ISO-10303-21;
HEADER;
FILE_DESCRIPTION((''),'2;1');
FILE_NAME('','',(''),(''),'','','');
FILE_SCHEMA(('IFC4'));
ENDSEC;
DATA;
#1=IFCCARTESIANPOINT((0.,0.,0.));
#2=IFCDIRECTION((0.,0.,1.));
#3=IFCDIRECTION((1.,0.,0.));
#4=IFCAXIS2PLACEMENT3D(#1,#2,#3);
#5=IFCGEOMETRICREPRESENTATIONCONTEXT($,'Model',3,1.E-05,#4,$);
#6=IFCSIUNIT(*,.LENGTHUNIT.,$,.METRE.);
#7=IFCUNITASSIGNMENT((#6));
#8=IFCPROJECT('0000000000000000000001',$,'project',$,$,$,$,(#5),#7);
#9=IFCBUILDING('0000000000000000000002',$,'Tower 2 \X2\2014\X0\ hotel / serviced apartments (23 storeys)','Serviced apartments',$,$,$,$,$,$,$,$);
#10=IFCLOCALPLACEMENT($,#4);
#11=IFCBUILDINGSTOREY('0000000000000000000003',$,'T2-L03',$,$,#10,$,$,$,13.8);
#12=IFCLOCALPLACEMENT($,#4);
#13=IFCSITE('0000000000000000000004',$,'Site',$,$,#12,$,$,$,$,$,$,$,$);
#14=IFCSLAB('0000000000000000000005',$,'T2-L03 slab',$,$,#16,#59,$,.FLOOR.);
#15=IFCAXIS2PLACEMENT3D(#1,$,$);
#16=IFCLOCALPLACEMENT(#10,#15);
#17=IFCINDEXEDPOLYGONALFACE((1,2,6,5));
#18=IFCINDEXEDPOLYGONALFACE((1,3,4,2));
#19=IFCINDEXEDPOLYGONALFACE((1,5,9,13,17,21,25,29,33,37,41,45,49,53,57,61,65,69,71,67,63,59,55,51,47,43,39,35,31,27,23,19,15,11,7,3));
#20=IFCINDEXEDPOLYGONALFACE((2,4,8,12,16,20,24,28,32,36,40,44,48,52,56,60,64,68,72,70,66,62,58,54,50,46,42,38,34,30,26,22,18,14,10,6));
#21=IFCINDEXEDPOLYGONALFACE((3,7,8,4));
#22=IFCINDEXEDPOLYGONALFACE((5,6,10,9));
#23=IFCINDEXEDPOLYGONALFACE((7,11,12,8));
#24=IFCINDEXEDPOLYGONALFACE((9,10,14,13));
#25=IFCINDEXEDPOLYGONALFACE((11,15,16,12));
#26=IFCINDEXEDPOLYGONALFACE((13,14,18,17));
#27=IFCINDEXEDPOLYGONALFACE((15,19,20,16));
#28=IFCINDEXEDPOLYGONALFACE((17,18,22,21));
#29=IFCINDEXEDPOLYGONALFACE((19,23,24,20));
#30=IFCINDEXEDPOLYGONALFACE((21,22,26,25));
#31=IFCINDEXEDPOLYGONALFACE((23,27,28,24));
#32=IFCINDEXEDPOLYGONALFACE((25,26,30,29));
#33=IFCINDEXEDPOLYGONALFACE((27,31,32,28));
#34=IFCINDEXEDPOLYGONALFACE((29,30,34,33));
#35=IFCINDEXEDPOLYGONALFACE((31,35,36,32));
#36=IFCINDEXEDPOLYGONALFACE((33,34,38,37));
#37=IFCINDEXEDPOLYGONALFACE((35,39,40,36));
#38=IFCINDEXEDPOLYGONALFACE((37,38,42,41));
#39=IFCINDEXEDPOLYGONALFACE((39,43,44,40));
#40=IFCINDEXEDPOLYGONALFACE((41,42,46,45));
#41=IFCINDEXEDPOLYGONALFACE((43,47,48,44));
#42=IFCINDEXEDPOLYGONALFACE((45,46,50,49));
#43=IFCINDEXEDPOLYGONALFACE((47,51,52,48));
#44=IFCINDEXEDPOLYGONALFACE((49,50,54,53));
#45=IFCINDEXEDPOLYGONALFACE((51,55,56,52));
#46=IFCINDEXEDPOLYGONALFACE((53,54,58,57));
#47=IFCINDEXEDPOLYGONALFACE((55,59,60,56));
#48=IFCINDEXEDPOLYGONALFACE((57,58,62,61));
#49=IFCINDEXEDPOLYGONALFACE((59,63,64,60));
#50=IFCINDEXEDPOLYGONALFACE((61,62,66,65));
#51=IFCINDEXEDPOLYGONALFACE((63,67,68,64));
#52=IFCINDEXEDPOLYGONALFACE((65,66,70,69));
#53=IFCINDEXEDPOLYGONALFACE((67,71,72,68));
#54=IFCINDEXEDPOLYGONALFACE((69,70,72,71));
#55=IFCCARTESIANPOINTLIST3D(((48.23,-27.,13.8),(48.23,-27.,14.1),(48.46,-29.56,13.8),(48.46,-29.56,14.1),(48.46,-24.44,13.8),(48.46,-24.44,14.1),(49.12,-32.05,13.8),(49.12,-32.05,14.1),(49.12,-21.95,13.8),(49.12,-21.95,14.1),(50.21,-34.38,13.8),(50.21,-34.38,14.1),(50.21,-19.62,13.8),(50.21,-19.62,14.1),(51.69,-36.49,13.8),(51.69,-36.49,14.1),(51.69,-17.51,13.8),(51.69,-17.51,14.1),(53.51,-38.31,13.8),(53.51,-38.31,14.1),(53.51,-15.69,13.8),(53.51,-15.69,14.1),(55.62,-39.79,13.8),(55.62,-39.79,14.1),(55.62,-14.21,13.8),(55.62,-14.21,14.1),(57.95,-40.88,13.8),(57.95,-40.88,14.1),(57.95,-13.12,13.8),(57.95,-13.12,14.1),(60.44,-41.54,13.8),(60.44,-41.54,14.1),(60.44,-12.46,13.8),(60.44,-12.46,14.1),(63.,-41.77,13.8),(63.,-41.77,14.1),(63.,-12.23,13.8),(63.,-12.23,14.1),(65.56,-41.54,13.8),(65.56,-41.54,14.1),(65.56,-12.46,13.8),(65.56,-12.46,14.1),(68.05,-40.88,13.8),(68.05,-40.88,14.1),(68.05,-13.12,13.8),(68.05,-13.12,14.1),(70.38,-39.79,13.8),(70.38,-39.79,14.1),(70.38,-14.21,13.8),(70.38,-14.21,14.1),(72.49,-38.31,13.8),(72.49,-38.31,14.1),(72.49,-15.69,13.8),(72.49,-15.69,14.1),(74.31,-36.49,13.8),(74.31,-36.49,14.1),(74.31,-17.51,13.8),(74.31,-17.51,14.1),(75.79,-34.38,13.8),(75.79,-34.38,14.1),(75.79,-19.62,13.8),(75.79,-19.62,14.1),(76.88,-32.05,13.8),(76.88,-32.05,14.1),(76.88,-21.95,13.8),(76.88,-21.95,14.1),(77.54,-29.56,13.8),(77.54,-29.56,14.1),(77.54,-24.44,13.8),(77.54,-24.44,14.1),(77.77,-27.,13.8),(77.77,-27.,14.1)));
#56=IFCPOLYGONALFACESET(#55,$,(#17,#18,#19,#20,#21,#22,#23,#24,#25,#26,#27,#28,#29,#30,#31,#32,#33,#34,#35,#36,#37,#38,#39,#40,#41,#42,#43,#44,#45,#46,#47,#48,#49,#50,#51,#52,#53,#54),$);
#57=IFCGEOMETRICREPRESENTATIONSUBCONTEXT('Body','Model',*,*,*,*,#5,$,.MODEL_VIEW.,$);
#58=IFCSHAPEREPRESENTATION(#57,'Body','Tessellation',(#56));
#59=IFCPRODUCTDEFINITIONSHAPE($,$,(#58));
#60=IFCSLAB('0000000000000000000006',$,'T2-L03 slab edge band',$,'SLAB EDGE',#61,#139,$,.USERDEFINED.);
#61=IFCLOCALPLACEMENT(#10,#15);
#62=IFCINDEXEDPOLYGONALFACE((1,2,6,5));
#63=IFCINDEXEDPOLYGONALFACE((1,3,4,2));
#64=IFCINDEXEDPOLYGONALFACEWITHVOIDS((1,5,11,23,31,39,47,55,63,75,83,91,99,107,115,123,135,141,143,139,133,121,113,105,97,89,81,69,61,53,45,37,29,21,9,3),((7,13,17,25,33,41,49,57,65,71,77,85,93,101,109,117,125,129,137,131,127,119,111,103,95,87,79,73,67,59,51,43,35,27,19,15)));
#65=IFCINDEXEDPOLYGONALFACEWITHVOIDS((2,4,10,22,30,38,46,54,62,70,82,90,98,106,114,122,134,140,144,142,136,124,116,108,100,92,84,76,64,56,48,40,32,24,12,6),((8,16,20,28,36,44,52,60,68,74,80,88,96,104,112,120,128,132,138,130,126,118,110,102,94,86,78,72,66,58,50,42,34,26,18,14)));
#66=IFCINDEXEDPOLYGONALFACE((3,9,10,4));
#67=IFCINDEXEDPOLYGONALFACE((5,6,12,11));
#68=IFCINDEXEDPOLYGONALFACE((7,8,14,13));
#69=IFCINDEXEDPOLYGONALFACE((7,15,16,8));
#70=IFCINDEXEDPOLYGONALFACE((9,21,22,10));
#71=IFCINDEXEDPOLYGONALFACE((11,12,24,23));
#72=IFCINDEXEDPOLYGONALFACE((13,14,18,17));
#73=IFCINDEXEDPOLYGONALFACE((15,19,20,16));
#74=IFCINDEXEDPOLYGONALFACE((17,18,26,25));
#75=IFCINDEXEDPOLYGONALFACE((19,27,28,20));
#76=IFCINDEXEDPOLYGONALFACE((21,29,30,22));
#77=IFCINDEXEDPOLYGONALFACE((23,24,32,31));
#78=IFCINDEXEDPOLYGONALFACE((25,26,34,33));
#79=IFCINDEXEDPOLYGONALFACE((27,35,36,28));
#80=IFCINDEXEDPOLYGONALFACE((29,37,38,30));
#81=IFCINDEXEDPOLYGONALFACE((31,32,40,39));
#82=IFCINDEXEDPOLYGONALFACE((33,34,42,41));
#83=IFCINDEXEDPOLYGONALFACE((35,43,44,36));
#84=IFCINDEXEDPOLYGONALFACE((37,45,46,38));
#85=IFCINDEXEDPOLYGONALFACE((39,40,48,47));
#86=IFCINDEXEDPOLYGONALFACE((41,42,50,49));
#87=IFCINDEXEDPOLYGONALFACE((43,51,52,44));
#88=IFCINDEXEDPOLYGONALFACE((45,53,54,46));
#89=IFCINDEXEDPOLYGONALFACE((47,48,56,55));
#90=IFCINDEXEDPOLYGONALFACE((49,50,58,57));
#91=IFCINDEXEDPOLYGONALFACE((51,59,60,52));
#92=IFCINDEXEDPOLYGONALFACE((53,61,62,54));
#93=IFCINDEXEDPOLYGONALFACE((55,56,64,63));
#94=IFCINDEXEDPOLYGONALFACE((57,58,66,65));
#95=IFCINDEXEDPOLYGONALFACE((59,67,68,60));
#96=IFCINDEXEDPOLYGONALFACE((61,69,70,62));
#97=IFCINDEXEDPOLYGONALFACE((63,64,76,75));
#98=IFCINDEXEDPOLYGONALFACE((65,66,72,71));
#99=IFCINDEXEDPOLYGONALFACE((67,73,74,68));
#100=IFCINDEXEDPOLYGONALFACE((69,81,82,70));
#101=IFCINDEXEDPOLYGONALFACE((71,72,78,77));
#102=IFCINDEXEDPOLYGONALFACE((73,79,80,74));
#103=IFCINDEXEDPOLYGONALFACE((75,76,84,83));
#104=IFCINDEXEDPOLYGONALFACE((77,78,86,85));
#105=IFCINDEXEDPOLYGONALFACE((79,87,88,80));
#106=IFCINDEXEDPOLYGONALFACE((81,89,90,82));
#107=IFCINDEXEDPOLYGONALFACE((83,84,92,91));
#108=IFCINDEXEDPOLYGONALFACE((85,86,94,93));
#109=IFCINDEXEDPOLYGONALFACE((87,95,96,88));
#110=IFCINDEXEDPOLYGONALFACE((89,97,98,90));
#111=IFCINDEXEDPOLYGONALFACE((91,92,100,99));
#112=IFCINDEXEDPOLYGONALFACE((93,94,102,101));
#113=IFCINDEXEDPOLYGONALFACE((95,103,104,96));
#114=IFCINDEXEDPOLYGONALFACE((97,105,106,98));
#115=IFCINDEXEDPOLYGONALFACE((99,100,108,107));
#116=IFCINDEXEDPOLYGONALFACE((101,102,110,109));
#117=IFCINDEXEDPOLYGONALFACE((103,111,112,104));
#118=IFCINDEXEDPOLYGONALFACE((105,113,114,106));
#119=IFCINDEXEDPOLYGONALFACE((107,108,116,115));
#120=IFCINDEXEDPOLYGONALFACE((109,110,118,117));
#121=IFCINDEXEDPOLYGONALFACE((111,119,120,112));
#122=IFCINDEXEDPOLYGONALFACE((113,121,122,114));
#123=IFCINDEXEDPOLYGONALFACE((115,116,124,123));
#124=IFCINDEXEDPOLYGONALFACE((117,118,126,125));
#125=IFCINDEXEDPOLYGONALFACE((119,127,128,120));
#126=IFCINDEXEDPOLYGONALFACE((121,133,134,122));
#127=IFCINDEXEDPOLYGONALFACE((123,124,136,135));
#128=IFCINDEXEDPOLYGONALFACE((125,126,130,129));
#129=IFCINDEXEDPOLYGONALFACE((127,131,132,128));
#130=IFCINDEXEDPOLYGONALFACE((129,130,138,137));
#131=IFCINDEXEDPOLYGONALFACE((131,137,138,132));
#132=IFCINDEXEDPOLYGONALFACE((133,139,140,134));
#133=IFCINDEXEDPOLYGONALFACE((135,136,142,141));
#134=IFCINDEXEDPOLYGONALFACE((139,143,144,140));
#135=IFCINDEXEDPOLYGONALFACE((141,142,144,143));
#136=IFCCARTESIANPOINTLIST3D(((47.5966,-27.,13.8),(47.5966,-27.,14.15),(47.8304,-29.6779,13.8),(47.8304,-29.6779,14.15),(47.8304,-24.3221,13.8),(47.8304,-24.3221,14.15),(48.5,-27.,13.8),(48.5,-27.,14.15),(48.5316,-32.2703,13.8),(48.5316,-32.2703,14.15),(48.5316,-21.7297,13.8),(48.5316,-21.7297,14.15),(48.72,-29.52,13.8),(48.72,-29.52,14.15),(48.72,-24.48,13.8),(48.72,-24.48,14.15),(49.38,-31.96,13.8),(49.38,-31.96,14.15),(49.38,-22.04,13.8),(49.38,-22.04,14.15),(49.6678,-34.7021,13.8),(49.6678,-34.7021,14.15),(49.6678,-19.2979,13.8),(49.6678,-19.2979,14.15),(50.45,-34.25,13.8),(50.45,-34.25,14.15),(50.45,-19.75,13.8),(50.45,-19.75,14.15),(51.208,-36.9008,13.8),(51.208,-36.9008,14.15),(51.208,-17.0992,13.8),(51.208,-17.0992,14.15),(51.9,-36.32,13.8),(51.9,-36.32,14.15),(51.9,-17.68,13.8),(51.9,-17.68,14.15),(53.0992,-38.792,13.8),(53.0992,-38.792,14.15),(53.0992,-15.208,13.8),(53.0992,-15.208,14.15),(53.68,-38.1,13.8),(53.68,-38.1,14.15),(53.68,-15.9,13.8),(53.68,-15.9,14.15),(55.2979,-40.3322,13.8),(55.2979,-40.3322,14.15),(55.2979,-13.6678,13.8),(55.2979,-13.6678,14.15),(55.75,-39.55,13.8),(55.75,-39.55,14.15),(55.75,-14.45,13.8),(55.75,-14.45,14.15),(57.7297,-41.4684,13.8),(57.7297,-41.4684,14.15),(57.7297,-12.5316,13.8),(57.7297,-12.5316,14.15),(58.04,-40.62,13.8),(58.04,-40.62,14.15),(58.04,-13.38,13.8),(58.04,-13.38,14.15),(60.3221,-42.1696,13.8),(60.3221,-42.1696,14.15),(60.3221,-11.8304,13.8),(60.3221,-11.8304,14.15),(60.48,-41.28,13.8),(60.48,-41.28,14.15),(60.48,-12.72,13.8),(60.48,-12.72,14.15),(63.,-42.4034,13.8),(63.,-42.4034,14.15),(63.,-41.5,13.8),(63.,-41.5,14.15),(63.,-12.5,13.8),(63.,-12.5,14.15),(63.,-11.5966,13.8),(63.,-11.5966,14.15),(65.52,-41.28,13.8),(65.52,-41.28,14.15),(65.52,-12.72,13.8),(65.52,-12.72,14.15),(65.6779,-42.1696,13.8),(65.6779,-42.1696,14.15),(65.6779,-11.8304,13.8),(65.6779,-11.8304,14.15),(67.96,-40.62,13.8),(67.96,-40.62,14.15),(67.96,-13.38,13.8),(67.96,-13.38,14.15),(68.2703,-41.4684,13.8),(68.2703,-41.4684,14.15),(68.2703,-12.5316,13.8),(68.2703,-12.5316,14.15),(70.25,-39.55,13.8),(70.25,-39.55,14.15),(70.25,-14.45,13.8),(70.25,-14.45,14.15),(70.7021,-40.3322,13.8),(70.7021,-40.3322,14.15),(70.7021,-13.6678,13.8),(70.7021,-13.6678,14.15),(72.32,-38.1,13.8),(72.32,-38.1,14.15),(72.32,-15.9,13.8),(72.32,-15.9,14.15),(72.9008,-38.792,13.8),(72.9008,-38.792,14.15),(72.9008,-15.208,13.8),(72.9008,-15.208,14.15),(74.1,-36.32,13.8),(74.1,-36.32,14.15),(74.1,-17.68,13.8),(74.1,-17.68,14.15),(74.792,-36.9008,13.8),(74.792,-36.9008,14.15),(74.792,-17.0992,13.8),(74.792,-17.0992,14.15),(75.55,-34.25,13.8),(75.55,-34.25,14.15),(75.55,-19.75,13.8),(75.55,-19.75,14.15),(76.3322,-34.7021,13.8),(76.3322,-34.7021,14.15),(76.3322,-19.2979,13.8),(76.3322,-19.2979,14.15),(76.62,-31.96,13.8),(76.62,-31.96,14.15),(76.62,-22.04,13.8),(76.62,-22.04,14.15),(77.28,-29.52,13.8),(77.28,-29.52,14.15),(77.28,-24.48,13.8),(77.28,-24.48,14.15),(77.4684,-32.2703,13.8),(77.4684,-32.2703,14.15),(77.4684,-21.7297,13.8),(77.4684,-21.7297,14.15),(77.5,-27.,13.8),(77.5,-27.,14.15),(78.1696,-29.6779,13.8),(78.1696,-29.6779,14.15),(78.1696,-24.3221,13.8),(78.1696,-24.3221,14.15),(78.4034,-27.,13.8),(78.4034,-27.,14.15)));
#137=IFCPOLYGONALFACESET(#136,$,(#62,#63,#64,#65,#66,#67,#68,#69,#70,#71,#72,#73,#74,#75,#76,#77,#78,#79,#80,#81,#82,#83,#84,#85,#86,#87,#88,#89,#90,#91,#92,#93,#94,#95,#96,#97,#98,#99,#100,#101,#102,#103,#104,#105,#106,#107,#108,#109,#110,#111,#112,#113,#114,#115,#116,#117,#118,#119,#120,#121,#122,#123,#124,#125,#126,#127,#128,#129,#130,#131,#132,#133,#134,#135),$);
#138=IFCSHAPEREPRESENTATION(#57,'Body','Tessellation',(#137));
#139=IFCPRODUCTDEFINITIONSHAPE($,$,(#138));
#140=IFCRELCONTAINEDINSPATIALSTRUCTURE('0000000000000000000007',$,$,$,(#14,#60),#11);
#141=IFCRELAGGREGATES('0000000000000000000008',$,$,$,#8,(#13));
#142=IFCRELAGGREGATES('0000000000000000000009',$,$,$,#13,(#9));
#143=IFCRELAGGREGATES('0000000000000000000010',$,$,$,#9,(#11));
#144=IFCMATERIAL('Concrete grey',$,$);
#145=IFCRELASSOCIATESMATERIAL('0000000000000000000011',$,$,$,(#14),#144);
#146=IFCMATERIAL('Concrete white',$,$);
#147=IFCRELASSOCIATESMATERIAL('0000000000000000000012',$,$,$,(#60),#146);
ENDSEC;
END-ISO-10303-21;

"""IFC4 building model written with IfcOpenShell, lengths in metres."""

from ifc_helpers import new_model, si_unit, frame, origin_with_axes, place, context, subcontext, project, spatial, polyline, outline, extrude, material, element, save


model = new_model("IFC4")

# Units and contexts
model_context = context("Model", 3, precision=1e-05, world=origin_with_axes())
body_context = subcontext(model_context, "Body", "Model", "MODEL_VIEW")
ifc_project = project(units=[si_unit("LENGTHUNIT", "METRE")], contexts=[model_context])

# Site, building, storey
site_placement = place(None, origin_with_axes())
site = spatial("IfcSite", under=ifc_project, at=site_placement, Name="Site")
building = spatial("IfcBuilding", under=site, Name="Tower 2 — hotel / serviced apartments (23 storeys)", Description="Serviced apartments")
storey_placement = place(None, origin_with_axes())
storey = spatial("IfcBuildingStorey", under=building, at=storey_placement, Name="T2-L03", Elevation=13.8)

# Slab
ifc_material_1 = material(Name="Concrete grey")
slab_1_placement = place(storey_placement, origin_with_axes())
element("IfcSlab", 1, at=slab_1_placement, inside=storey, material=ifc_material_1, Name="T2-L03 slab", PredefinedType="FLOOR", context=body_context, shape_type="SweptSolid", body=[
    extrude(outline(polyline([(77.54, -29.56), (77.77, -27.0), (77.54, -24.44), (76.88, -21.95), (75.79, -19.62), (74.31, -17.51), (72.49, -15.69), (70.38, -14.21), (68.05, -13.12), (65.56, -12.46), (63.0, -12.23), (60.44, -12.46), (57.95, -13.12), (55.62, -14.21), (53.51, -15.69), (51.69, -17.51), (50.21, -19.62), (49.12, -21.95), (48.46, -24.44), (48.23, -27.0), (48.46, -29.56), (49.12, -32.05), (50.21, -34.38), (51.69, -36.49), (53.51, -38.31), (55.62, -39.79), (57.95, -40.88), (60.44, -41.54), (63.0, -41.77), (65.56, -41.54), (68.05, -40.88), (70.38, -39.79), (72.49, -38.31), (74.31, -36.49), (75.79, -34.38), (76.88, -32.05), (77.54, -29.56)])), frame((0.0, 0.0, 13.8), z_axis=(0.0, 0.0, 1.0), x_axis=(1.0, 0.0, 0.0)), (0.0, 0.0, 1.0), 0.3),
])

# Slab
ifc_material_2 = material(Name="Concrete white")
slab_2_placement = place(storey_placement, origin_with_axes())
element("IfcSlab", 2, at=slab_2_placement, inside=storey, material=ifc_material_2, Name="T2-L03 slab edge band", ObjectType="SLAB EDGE", PredefinedType="USERDEFINED", context=body_context, shape_type="SweptSolid", body=[
    extrude(outline(polyline([(78.4034, -27.0), (78.1696, -24.3221), (77.4684, -21.7297), (76.3322, -19.2979), (74.792, -17.0992), (72.9008, -15.208), (70.7021, -13.6678), (68.2703, -12.5316), (65.6779, -11.8304), (63.0, -11.5966), (60.3221, -11.8304), (57.7297, -12.5316), (55.2979, -13.6678), (53.0992, -15.208), (51.208, -17.0992), (49.6678, -19.2979), (48.5316, -21.7297), (47.8304, -24.3221), (47.5966, -27.0), (47.8304, -29.6779), (48.5316, -32.2703), (49.6678, -34.7021), (51.208, -36.9008), (53.0992, -38.792), (55.2979, -40.3322), (57.7297, -41.4684), (60.3221, -42.1696), (63.0, -42.4034), (65.6779, -42.1696), (68.2703, -41.4684), (70.7021, -40.3322), (72.9008, -38.792), (74.792, -36.9008), (76.3322, -34.7021), (77.4684, -32.2703), (78.1696, -29.6779), (78.4034, -27.0)]), holes=[polyline([(77.5, -27.0), (77.28, -24.48), (76.62, -22.04), (75.55, -19.75), (74.1, -17.68), (72.32, -15.9), (70.25, -14.45), (67.96, -13.38), (65.52, -12.72), (63.0, -12.5), (60.48, -12.72), (58.04, -13.38), (55.75, -14.45), (53.68, -15.9), (51.9, -17.68), (50.45, -19.75), (49.38, -22.04), (48.72, -24.48), (48.5, -27.0), (48.72, -29.52), (49.38, -31.96), (50.45, -34.25), (51.9, -36.32), (53.68, -38.1), (55.75, -39.55), (58.04, -40.62), (60.48, -41.28), (63.0, -41.5), (65.52, -41.28), (67.96, -40.62), (70.25, -39.55), (72.32, -38.1), (74.1, -36.32), (75.55, -34.25), (76.62, -31.96), (77.28, -29.52), (77.5, -27.0)])]), frame((0.0, 0.0, 13.8), z_axis=(0.0, 0.0, 1.0), x_axis=(1.0, 0.0, 0.0)), (0.0, 0.0, 1.0), 0.35),
])

save(model, "model.ifc")
